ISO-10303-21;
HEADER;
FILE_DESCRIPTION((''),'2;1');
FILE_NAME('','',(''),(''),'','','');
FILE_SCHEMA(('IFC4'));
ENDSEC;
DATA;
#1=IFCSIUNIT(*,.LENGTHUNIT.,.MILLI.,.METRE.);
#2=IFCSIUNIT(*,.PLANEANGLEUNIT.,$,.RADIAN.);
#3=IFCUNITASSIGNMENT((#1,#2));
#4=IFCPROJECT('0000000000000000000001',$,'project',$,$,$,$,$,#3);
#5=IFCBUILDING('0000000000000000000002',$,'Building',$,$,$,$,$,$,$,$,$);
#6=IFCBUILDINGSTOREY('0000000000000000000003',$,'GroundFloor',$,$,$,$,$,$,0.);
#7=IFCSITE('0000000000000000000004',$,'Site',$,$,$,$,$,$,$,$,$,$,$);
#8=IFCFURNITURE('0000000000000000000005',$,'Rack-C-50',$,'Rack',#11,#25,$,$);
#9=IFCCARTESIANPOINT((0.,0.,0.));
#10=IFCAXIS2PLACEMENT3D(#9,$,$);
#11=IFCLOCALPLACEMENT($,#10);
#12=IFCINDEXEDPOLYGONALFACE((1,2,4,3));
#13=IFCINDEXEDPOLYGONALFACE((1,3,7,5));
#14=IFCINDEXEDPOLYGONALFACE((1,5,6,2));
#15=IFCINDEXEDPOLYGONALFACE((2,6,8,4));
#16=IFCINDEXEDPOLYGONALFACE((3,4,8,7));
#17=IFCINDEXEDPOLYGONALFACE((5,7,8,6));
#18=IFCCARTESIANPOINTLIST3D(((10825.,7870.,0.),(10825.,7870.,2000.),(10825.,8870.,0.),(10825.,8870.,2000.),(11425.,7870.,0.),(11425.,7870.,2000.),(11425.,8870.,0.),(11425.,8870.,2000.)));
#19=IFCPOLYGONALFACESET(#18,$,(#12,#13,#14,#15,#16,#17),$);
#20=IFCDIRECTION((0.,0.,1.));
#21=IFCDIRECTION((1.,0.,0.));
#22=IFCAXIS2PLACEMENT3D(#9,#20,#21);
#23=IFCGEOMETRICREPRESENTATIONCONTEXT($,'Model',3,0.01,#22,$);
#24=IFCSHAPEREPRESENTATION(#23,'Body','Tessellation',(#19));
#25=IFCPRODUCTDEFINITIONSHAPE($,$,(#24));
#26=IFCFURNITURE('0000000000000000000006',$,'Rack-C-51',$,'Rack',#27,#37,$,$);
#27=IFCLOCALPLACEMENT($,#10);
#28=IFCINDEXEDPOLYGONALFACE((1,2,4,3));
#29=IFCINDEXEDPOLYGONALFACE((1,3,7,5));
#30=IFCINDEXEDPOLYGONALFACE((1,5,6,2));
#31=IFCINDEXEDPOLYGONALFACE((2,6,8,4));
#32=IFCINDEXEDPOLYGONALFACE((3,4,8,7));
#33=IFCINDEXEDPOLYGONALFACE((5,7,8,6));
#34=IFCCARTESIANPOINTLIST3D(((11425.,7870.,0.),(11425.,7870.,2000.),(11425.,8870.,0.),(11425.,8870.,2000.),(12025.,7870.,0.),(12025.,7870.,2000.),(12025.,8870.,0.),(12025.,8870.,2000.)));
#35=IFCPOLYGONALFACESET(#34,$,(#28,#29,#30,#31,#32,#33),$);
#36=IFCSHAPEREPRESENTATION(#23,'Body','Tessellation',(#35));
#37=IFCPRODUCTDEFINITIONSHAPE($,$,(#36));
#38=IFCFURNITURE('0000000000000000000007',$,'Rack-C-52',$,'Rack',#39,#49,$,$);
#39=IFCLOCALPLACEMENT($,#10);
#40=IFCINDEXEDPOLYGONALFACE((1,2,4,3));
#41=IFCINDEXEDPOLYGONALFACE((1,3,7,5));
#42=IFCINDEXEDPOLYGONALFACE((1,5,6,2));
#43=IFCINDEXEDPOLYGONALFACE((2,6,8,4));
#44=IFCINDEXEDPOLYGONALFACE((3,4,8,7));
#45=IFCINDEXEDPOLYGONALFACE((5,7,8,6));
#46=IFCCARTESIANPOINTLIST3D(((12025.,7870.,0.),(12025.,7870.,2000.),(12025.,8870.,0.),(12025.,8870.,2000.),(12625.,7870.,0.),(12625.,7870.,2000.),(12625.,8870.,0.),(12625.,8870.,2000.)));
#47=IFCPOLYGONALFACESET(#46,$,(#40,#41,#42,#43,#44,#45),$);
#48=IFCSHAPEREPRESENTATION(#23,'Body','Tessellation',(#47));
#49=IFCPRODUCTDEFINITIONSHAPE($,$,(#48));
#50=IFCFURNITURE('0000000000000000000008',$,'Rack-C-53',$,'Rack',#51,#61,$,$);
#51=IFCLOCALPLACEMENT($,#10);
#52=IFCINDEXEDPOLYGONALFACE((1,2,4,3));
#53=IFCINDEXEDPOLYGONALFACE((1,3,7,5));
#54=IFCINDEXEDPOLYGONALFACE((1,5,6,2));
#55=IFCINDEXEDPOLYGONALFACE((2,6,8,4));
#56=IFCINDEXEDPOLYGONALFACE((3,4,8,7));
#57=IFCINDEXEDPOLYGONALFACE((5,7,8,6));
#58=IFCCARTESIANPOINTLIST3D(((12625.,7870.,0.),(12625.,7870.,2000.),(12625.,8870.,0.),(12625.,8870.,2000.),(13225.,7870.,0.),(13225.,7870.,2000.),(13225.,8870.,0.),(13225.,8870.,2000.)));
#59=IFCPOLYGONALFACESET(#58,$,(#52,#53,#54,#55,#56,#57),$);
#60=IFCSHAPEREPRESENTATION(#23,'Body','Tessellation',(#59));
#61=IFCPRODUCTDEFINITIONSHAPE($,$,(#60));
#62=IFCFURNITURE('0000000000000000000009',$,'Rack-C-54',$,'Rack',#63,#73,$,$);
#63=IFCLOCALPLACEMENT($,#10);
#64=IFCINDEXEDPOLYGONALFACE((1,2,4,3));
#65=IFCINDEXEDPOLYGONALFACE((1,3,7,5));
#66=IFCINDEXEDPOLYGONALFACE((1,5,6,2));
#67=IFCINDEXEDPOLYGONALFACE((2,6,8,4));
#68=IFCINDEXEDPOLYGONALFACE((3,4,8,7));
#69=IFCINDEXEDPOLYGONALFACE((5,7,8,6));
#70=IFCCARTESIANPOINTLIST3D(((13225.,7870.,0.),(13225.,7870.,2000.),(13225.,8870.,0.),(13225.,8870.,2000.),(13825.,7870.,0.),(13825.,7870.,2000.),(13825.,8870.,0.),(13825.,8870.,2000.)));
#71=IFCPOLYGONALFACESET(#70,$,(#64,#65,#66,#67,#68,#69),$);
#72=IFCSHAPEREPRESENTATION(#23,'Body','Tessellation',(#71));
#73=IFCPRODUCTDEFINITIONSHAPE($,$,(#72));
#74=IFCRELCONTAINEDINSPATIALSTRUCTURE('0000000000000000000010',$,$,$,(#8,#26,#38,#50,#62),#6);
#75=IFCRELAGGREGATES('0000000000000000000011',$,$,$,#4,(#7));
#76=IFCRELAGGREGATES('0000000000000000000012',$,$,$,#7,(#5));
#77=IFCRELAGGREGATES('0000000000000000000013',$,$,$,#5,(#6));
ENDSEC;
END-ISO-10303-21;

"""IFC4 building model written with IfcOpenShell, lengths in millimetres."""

from ifc_helpers import new_model, si_unit, frame, origin, origin_with_axes, origin_2d, place, context, project, spatial, rectangle, extrude, element, save


model = new_model("IFC4")

# Units and contexts
model_context = context("Model", 3, precision=0.01, world=origin_with_axes())
ifc_project = project(units=[si_unit("LENGTHUNIT", "METRE", prefix="MILLI"), si_unit("PLANEANGLEUNIT", "RADIAN")])

# Site, building, storey
site = spatial("IfcSite", under=ifc_project, Name="Site")
building = spatial("IfcBuilding", under=site, Name="Building")
storey = spatial("IfcBuildingStorey", under=building, Name="GroundFloor", Elevation=0.0)

# Furniture
for number, where, z_axis, x_axis, name in (
    (1, (11125.0, 8370.0, 0.0), (0.0, 0.0, 1.0), (1.0, 0.0, 0.0), "Rack-C-50"),
    (2, (11725.0, 8370.0, 0.0), (0.0, 0.0, 1.0), (1.0, 0.0, 0.0), "Rack-C-51"),
    (3, (12325.0, 8370.0, 0.0), (0.0, 0.0, 1.0), (1.0, 0.0, 0.0), "Rack-C-52"),
    (4, (12925.0, 8370.0, 0.0), (0.0, 0.0, 1.0), (1.0, 0.0, 0.0), "Rack-C-53"),
    (5, (13525.0, 8370.0, 0.0), (0.0, 0.0, 1.0), (1.0, 0.0, 0.0), "Rack-C-54"),
):
    element("IfcFurniture", number, at=place(None, frame(where, z_axis=z_axis, x_axis=x_axis)), inside=storey, Name=name, ObjectType="Rack", context=model_context, shape_type="SweptSolid", body=[
        extrude(rectangle(XDim=600.0, YDim=1000.0, at=origin_2d()), origin(), (0.0, 0.0, 1.0), 2000.0),
    ])

save(model, "model.ifc")
